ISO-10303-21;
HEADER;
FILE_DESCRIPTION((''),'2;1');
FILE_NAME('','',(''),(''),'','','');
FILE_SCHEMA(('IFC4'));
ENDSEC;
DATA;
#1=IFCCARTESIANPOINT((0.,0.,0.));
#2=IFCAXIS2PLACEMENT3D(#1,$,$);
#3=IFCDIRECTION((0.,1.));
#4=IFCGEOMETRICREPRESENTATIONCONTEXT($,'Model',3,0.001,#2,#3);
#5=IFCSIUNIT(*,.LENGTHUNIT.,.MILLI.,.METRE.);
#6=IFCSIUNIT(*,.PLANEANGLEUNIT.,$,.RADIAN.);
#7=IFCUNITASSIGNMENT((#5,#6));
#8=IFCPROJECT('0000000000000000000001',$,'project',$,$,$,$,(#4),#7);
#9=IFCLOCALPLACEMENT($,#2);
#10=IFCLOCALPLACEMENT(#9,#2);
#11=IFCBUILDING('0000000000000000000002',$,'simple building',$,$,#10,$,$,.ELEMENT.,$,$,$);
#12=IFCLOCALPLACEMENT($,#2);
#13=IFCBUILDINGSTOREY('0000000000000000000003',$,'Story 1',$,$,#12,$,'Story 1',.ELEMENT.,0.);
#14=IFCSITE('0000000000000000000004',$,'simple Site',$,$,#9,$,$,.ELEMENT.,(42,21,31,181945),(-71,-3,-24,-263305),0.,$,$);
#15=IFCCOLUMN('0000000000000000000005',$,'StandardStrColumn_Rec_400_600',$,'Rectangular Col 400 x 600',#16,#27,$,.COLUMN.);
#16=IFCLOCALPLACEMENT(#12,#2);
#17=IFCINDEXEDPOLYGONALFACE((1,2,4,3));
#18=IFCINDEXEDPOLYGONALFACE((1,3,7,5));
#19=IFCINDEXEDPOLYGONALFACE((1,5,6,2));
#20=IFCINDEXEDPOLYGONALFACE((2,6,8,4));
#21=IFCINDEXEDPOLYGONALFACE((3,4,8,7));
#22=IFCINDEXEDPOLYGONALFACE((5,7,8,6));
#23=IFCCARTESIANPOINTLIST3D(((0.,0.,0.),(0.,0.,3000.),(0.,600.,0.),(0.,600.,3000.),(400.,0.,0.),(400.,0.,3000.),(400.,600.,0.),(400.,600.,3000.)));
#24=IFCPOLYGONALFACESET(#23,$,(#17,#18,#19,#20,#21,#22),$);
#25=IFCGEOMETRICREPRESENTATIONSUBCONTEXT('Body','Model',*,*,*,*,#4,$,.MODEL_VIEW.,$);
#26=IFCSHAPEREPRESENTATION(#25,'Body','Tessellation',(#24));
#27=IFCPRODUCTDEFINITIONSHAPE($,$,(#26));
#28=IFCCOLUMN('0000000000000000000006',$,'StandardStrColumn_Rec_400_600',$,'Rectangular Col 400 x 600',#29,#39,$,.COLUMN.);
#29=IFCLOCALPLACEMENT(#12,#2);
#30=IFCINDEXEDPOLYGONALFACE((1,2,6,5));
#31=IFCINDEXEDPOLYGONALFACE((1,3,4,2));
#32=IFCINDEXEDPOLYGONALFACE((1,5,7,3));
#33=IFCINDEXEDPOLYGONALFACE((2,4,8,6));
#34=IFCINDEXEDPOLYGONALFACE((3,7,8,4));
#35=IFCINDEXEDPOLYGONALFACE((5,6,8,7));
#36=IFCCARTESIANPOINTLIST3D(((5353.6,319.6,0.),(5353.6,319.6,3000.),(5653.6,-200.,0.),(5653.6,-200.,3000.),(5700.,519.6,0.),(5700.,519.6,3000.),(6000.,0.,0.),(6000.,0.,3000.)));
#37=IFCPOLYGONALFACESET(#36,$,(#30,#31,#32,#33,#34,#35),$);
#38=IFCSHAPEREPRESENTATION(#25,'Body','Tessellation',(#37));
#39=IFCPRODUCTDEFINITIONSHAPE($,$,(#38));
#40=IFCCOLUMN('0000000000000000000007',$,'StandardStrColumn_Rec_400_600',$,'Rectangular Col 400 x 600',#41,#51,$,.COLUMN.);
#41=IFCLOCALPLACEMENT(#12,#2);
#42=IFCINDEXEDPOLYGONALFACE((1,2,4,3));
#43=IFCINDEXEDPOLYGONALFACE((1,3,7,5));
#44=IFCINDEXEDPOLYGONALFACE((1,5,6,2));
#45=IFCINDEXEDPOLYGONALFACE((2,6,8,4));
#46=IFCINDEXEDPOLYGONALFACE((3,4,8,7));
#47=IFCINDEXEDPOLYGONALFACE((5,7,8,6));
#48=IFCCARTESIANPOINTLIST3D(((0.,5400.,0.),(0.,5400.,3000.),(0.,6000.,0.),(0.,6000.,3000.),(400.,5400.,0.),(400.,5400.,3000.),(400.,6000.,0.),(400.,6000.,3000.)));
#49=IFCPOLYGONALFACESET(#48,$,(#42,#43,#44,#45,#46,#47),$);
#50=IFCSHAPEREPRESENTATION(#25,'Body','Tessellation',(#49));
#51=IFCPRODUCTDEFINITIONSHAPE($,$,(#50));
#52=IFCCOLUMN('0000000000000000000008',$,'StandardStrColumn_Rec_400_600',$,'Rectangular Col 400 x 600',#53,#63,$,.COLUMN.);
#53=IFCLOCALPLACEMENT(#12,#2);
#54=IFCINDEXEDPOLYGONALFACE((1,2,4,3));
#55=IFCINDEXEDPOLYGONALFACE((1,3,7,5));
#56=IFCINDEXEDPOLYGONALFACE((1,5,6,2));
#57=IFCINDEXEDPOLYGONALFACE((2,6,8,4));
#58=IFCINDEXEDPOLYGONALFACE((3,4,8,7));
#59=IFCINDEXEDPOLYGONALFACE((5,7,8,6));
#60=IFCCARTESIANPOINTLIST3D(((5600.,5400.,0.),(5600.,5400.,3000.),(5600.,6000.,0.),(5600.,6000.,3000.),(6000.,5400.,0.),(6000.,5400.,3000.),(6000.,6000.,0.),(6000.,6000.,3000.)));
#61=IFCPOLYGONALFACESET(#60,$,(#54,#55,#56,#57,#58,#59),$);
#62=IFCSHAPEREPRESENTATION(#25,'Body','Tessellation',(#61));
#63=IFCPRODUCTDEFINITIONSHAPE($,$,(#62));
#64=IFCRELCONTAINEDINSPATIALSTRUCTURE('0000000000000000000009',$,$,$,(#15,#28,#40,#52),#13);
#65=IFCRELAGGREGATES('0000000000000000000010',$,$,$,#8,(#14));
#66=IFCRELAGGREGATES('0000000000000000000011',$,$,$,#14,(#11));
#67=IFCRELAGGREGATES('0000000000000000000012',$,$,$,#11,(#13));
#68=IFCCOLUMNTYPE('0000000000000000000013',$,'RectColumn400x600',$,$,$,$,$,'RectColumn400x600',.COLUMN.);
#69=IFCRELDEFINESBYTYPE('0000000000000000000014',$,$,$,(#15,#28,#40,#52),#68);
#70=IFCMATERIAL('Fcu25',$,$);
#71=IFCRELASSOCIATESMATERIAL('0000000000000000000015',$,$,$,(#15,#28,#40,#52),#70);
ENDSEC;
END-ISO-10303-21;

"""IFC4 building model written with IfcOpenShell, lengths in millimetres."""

from ifc_helpers import new_model, si_unit, direction, frame, origin, origin_with_axes, origin_2d_with_axis, place, context, subcontext, project, spatial, rectangle, extrude, material, material_profile, profile_set, profile_usage, type_object, element, save


model = new_model("IFC4")

# Units and contexts
model_context = context("Model", 3, precision=0.001, world=origin(), true_north=direction((0.0, 1.0)))
body_context = subcontext(model_context, "Body", "Model", "MODEL_VIEW")
ifc_project = project(units=[si_unit("LENGTHUNIT", "METRE", prefix="MILLI"), si_unit("PLANEANGLEUNIT", "RADIAN")], contexts=[model_context])

# Site, building, storey
site_placement = place(None, origin())
site = spatial("IfcSite", under=ifc_project, at=site_placement, Name="simple Site", CompositionType="ELEMENT", RefLatitude=(42, 21, 31, 181945), RefLongitude=(-71, -3, -24, -263305), RefElevation=0.0)
building_placement = place(site_placement, origin())
building = spatial("IfcBuilding", under=site, at=building_placement, Name="simple building", CompositionType="ELEMENT")
storey_placement = place(None, origin())
storey = spatial("IfcBuildingStorey", under=building, at=storey_placement, Name="Story 1", LongName="Story 1", CompositionType="ELEMENT", Elevation=0.0)

# Columns
ifc_material = material(Name="Fcu25")
ifc_material_profile = material_profile(ifc_material, rectangle(XDim=400.0, YDim=600.0, at=origin_2d_with_axis()))
ifc_profile_set = profile_set([ifc_material_profile])
ifc_profile_usage_1 = profile_usage(ifc_profile_set, cardinal=7)
column_type = type_object("IfcColumnType", Name="RectColumn400x600", ElementType="RectColumn400x600", PredefinedType="COLUMN")
column_1_placement = place(None, frame((200.0, 300.0, 0.0), z_axis=(0.0, 0.0, 1.0), x_axis=(1.0, 0.0, 0.0)))
element("IfcColumn", 1, at=column_1_placement, inside=storey, type_object=column_type, material=ifc_profile_usage_1, Name="StandardStrColumn_Rec_400_600", ObjectType="Rectangular Col 400 x 600", PredefinedType="COLUMN", context=body_context, shape_type="SweptSolid", body=[
    extrude(rectangle(XDim=400.0, YDim=600.0, at=origin_2d_with_axis()), origin_with_axes(), (0.0, 0.0, 1.0), 3000.0),
])
ifc_profile_usage_2 = profile_usage(ifc_profile_set, cardinal=9)
column_2_placement = place(None, frame((5676.8, 159.8, 0.0), z_axis=(0.0, 0.0, 1.0), x_axis=(0.866025, 0.5, 0.0)))
element("IfcColumn", 2, at=column_2_placement, inside=storey, type_object=column_type, material=ifc_profile_usage_2, Name="StandardStrColumn_Rec_400_600", ObjectType="Rectangular Col 400 x 600", PredefinedType="COLUMN", context=body_context, shape_type="SweptSolid", body=[
    extrude(rectangle(XDim=400.0, YDim=600.0, at=origin_2d_with_axis()), origin_with_axes(), (0.0, 0.0, 1.0), 3000.0),
])
ifc_profile_usage_3 = profile_usage(ifc_profile_set, cardinal=1)
column_3_placement = place(None, frame((200.0, 5700.0, 0.0), z_axis=(0.0, 0.0, 1.0), x_axis=(1.0, 0.0, 0.0)))
element("IfcColumn", 3, at=column_3_placement, inside=storey, type_object=column_type, material=ifc_profile_usage_3, Name="StandardStrColumn_Rec_400_600", ObjectType="Rectangular Col 400 x 600", PredefinedType="COLUMN", context=body_context, shape_type="SweptSolid", body=[
    extrude(rectangle(XDim=400.0, YDim=600.0, at=origin_2d_with_axis()), origin_with_axes(), (0.0, 0.0, 1.0), 3000.0),
])
ifc_profile_usage_4 = profile_usage(ifc_profile_set, cardinal=3)
column_4_placement = place(None, frame((5800.0, 5700.0, 0.0), z_axis=(0.0, 0.0, 1.0), x_axis=(1.0, 0.0, 0.0)))
element("IfcColumn", 4, at=column_4_placement, inside=storey, type_object=column_type, material=ifc_profile_usage_4, Name="StandardStrColumn_Rec_400_600", ObjectType="Rectangular Col 400 x 600", PredefinedType="COLUMN", context=body_context, shape_type="SweptSolid", body=[
    extrude(rectangle(XDim=400.0, YDim=600.0, at=origin_2d_with_axis()), origin_with_axes(), (0.0, 0.0, 1.0), 3000.0),
])

save(model, "model.ifc")
